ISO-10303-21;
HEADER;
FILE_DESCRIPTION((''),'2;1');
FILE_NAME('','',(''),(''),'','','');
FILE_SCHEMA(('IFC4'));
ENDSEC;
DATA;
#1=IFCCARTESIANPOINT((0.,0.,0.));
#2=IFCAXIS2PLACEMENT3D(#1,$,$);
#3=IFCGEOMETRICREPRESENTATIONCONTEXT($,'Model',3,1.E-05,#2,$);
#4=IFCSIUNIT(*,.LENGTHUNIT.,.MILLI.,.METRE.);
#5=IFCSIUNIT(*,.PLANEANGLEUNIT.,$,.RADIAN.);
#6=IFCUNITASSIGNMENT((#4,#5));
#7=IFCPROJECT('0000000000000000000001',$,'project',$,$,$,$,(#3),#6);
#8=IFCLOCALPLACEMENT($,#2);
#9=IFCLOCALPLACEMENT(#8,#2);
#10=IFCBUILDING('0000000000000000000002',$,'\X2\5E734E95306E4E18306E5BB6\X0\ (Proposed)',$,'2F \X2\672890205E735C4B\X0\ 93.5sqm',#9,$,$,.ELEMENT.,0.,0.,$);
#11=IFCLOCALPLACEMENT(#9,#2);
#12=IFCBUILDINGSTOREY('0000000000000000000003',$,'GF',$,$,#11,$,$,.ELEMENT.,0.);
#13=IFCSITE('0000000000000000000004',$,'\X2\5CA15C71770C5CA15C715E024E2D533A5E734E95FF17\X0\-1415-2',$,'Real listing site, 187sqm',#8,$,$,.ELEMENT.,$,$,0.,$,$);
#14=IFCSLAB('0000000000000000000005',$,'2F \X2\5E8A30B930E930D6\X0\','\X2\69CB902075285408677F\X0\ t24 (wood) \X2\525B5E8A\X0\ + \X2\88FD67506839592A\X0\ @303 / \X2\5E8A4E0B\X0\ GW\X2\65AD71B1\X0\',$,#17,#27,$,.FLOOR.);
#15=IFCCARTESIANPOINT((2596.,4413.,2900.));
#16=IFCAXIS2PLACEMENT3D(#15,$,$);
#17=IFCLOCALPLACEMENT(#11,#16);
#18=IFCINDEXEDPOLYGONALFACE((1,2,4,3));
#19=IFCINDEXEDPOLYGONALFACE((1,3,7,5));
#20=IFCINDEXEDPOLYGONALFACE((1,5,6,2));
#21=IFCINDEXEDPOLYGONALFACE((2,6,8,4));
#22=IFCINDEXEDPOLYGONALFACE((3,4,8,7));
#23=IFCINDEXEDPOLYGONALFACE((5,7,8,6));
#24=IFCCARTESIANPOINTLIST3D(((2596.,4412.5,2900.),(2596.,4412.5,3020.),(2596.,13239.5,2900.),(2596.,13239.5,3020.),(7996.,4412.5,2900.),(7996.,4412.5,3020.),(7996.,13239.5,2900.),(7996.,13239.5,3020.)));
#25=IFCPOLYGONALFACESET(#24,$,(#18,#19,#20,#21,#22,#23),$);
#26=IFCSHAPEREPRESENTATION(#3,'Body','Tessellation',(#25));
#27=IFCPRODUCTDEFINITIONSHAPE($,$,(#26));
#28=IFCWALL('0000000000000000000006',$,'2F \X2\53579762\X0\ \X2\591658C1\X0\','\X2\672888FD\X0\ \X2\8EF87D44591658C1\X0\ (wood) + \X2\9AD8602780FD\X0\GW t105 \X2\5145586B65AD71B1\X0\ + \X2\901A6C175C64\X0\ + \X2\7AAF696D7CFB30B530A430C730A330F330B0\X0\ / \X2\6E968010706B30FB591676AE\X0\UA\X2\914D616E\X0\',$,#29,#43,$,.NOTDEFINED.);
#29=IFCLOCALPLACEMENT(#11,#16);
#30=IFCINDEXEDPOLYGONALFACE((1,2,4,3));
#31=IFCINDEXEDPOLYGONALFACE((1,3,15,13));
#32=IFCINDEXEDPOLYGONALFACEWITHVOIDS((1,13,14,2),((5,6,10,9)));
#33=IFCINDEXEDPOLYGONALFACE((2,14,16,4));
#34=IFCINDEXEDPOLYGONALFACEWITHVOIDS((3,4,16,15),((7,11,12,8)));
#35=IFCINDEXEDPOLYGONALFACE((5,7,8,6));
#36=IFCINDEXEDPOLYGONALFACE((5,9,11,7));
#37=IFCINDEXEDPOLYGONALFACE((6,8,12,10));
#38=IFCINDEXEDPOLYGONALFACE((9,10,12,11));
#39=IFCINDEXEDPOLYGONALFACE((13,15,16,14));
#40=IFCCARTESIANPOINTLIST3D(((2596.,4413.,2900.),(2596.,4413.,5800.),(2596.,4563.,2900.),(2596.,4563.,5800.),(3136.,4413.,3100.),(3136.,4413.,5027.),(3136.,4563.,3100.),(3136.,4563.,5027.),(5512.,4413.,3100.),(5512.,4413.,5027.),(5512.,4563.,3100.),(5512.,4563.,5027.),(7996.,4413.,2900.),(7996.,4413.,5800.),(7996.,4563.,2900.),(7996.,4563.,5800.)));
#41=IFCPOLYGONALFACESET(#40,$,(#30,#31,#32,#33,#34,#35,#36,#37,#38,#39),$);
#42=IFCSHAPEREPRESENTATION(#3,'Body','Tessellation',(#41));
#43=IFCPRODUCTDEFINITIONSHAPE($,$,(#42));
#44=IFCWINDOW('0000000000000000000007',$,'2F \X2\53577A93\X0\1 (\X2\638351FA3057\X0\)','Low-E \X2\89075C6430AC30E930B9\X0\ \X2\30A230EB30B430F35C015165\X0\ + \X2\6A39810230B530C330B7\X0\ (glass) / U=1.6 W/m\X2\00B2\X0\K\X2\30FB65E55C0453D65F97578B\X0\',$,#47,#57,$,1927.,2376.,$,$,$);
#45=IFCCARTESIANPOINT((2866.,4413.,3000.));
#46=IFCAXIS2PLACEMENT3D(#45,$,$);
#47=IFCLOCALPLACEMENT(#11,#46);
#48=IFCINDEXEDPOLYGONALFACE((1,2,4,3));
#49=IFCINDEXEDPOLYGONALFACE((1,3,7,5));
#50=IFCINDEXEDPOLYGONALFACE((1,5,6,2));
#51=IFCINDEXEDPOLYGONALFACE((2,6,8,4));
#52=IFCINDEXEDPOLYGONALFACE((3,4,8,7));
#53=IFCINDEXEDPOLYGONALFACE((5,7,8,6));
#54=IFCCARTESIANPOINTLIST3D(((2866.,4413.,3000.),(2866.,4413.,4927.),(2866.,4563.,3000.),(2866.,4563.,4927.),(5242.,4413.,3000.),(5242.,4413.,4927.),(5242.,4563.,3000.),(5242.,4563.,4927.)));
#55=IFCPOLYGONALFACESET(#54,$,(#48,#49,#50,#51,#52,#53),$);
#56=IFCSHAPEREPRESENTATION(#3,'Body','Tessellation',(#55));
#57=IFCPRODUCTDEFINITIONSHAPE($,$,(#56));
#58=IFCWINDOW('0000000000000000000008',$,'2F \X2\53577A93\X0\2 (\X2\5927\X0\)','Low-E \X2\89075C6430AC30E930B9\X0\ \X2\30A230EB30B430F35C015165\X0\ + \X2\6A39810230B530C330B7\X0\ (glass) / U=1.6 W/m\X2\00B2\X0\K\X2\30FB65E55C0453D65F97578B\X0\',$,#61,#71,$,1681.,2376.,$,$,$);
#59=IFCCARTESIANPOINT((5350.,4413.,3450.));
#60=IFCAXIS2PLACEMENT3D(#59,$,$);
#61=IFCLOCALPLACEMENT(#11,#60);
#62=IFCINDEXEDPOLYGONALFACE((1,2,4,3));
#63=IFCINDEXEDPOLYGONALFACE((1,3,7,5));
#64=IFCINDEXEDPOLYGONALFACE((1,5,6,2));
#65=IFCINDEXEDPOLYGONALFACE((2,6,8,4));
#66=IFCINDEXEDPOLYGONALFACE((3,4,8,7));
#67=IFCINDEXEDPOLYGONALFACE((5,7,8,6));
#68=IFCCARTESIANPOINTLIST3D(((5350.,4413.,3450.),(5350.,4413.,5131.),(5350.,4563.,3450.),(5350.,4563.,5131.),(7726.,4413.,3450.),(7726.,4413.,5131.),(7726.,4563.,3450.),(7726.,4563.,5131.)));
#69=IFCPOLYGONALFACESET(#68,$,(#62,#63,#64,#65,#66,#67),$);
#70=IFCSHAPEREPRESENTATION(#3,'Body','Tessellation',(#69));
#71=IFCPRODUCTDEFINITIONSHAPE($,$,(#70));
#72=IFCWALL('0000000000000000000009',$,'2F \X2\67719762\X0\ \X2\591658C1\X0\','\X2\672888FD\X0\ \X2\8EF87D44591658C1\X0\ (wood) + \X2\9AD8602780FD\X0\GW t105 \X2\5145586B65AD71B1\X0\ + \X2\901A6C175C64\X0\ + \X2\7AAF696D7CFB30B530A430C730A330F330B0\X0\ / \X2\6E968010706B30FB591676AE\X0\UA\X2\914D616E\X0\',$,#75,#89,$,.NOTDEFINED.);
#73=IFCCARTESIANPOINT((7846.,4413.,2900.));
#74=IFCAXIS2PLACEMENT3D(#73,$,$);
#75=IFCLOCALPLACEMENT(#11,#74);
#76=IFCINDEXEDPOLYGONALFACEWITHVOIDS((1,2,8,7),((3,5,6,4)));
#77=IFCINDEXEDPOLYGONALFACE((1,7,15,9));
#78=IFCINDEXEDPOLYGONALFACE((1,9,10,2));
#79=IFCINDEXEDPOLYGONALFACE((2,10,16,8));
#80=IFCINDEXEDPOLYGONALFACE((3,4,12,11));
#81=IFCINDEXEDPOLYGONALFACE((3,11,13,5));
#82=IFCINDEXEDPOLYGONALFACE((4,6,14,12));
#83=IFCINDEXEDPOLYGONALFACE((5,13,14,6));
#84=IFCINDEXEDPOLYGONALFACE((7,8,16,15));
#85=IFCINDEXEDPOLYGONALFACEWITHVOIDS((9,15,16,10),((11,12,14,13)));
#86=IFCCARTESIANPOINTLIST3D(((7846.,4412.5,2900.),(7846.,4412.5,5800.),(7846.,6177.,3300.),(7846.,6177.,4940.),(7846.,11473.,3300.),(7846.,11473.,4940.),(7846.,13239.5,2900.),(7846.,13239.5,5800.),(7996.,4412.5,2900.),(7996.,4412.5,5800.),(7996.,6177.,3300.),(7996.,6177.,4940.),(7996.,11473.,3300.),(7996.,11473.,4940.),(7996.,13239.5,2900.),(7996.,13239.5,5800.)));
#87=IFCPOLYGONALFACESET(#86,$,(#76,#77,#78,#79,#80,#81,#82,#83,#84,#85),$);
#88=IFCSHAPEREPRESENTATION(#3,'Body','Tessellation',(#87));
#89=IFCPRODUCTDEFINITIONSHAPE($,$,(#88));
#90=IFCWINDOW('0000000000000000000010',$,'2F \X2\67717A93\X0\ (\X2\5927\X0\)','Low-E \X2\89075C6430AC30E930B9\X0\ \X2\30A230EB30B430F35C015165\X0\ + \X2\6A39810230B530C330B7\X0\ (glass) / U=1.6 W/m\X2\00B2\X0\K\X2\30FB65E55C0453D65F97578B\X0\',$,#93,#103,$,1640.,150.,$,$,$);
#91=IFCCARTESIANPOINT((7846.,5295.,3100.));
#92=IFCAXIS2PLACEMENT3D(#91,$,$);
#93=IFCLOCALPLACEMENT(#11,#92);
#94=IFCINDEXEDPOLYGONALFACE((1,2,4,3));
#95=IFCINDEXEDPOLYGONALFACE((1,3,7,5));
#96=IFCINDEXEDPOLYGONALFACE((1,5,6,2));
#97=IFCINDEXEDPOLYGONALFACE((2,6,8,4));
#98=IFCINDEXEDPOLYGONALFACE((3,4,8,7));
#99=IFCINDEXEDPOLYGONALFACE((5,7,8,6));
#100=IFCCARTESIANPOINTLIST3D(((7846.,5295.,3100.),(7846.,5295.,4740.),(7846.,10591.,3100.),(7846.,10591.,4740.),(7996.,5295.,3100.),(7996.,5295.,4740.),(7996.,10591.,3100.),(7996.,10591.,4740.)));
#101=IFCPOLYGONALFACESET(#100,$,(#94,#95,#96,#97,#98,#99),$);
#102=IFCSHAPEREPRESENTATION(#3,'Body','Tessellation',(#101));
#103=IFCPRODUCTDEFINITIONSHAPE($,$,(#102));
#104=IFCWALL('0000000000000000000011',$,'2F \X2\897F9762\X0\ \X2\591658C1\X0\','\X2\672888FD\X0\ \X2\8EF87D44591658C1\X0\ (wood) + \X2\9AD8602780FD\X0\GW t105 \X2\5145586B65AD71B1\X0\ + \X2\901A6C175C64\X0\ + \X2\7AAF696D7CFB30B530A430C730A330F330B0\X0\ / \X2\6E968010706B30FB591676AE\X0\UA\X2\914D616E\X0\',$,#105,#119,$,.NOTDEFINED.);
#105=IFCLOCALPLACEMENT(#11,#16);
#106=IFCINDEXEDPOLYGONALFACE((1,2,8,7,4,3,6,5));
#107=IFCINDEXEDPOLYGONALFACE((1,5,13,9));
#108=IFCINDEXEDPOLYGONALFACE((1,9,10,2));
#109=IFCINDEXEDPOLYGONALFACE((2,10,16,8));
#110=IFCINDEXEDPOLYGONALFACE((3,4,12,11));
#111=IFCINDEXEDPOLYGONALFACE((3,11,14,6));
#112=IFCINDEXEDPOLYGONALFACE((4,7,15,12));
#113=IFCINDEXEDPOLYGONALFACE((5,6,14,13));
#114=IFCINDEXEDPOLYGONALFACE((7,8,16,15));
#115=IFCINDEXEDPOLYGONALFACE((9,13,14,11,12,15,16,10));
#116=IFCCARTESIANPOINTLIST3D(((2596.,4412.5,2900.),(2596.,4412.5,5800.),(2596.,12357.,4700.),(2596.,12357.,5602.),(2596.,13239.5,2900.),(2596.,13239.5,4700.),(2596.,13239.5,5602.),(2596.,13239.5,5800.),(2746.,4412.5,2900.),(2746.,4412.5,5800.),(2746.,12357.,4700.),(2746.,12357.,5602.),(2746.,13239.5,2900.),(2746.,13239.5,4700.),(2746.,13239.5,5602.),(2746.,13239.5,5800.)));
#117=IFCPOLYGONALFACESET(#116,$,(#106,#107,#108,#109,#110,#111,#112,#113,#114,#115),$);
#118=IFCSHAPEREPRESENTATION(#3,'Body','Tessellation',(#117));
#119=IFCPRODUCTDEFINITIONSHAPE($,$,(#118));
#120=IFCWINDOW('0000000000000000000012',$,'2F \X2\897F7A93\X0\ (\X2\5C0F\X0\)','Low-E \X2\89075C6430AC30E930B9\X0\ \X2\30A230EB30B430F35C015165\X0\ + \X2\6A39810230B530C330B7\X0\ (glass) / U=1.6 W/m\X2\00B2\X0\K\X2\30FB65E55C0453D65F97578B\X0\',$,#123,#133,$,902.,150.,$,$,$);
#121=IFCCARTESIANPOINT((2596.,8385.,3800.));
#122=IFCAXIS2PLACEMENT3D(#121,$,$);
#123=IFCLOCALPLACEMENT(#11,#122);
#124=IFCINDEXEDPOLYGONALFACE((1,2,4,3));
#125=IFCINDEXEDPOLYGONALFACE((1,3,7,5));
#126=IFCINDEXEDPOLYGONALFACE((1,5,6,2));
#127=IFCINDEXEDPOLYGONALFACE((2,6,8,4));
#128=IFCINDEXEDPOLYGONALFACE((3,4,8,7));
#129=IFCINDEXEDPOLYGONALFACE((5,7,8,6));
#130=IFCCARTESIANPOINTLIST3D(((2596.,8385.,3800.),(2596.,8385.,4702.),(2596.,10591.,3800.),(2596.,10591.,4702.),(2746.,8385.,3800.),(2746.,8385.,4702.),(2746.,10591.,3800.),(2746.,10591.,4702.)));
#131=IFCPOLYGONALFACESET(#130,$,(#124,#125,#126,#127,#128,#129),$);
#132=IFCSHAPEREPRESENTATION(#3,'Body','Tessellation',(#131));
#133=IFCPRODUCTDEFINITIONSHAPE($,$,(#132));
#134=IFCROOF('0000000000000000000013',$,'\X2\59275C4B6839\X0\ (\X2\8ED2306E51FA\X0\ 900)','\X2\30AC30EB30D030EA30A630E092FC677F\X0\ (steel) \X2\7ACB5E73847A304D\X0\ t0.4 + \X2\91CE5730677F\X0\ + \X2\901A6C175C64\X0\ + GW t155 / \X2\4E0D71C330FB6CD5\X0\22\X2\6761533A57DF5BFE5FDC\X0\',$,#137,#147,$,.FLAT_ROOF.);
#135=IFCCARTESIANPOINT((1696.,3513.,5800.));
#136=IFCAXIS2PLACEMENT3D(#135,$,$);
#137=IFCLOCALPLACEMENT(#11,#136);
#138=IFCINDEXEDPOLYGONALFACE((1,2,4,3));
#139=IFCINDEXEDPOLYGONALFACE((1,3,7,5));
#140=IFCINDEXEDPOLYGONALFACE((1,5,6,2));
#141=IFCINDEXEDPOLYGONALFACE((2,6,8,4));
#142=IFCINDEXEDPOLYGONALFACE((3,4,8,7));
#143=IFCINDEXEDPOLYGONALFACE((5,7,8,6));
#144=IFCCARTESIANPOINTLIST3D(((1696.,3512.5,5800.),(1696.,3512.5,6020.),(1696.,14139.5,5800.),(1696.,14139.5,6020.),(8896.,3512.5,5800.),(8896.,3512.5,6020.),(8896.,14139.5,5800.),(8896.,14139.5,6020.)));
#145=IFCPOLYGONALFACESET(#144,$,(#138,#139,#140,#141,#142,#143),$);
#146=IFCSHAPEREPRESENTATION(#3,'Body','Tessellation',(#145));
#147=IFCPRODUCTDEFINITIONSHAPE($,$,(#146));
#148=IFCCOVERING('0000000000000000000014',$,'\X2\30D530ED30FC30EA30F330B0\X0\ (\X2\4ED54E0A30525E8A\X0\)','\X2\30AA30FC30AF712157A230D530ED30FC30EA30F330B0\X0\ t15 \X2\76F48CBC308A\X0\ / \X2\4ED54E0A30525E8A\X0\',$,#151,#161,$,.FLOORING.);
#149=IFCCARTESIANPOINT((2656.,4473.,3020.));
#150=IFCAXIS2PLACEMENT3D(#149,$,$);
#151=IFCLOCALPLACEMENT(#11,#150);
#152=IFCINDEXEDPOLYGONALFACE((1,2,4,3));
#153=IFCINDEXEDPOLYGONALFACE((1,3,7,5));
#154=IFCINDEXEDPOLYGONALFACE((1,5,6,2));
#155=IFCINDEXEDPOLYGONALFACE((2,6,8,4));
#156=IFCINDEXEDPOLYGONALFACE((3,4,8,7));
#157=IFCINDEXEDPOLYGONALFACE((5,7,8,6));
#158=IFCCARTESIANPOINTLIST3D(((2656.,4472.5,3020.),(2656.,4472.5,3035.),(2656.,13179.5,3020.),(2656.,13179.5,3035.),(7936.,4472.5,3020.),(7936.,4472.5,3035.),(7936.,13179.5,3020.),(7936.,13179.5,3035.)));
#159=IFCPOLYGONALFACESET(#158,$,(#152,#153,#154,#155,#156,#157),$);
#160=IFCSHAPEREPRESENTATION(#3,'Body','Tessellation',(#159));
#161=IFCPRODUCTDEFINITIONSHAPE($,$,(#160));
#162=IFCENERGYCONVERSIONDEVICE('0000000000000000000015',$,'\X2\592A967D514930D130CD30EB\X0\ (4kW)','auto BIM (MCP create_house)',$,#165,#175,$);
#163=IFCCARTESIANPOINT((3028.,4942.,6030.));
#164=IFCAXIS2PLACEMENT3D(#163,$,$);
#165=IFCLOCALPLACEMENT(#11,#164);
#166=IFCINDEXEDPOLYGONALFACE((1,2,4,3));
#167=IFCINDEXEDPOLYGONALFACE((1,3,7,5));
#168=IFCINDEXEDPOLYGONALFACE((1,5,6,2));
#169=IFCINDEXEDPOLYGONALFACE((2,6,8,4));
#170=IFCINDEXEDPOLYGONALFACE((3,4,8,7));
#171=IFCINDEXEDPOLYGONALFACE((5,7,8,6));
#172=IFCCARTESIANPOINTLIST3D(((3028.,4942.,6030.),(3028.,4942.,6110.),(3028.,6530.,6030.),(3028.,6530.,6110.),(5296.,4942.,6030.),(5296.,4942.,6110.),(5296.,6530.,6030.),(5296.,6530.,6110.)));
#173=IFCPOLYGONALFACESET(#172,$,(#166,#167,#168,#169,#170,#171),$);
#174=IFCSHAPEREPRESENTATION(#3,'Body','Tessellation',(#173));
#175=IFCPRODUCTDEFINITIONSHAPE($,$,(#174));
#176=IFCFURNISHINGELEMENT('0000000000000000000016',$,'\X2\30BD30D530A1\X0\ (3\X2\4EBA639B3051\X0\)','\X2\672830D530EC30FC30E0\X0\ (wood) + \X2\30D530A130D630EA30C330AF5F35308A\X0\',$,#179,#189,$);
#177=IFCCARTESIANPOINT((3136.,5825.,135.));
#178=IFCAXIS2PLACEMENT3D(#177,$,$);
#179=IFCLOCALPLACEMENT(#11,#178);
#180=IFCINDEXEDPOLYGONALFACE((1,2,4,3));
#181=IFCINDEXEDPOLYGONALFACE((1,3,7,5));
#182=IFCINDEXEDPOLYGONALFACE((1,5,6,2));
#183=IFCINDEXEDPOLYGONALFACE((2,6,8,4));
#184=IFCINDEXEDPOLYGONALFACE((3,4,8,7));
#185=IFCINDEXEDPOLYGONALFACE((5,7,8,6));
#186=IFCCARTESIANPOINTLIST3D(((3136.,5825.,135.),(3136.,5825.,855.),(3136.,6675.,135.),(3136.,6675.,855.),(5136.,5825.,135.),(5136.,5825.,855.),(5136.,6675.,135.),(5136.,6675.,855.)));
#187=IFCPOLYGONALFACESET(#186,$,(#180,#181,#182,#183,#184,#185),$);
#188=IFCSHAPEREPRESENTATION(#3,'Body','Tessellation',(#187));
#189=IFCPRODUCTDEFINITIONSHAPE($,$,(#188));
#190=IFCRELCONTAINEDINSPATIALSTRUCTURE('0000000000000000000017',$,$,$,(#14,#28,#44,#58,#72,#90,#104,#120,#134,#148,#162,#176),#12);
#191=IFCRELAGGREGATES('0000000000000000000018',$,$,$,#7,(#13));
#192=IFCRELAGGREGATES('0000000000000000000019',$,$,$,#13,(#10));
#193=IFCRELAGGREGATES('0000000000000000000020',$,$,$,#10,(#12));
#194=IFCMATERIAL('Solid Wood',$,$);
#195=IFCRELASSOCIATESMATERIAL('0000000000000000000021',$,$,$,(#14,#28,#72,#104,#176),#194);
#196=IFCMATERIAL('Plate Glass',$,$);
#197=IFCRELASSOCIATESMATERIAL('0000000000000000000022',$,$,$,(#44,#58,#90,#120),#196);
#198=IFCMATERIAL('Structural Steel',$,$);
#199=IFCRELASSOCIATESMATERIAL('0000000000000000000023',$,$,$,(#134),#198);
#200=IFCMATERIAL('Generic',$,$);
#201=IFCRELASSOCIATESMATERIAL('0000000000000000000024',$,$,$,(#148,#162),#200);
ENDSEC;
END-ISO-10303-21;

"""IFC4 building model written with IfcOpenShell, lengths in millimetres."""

from ifc_helpers import new_model, si_unit, frame, frame_2d, origin, place, context, project, spatial, rectangle, extrude, material, element, fill, save


model = new_model("IFC4")

# Units and contexts
model_context = context("Model", 3, precision=1e-05, world=origin())
ifc_project = project(units=[si_unit("LENGTHUNIT", "METRE", prefix="MILLI"), si_unit("PLANEANGLEUNIT", "RADIAN")], contexts=[model_context])

# Site, building, storey
site_placement = place(None, origin())
site = spatial("IfcSite", under=ifc_project, at=site_placement, Name="岡山県岡山市中区平井７-1415-2", ObjectType="Real listing site, 187sqm", CompositionType="ELEMENT", RefElevation=0.0)
building_placement = place(site_placement, origin())
building = spatial("IfcBuilding", under=site, at=building_placement, Name="平井の丘の家 (Proposed)", ObjectType="2F 木造平屋 93.5sqm", CompositionType="ELEMENT", ElevationOfRefHeight=0.0, ElevationOfTerrain=0.0)
storey_placement = place(building_placement, origin())
storey = spatial("IfcBuildingStorey", under=building, at=storey_placement, Name="GF", CompositionType="ELEMENT", Elevation=0.0)

# Slab
ifc_material_1 = material(Name="Solid Wood")
slab_placement = place(storey_placement, frame((2596.0, 4413.0, 2900.0)))
element("IfcSlab", 1, at=slab_placement, inside=storey, material=ifc_material_1, Name="2F 床スラブ", Description="構造用合板 t24 (wood) 剛床 + 製材根太 @303 / 床下 GW断熱", PredefinedType="FLOOR", context=model_context, shape_type="SweptSolid", body=[
    extrude(rectangle(XDim=5400.0, YDim=8827.0, at=frame_2d((2700.0, 4413.0))), frame((2596.0, 4413.0, 2900.0)), (0.0, 0.0, 1.0), 120.0),
])

# Wall, openings, windows
wall_1_placement = place(storey_placement, frame((2596.0, 4413.0, 2900.0)))
wall_1 = element("IfcWall", 2, at=wall_1_placement, inside=storey, material=ifc_material_1, Name="2F 南面 外壁", Description="木製 軸組外壁 (wood) + 高性能GW t105 充填断熱 + 通気層 + 窯業系サイディング / 準耐火・外皮UA配慮", PredefinedType="NOTDEFINED", context=model_context, shape_type="SweptSolid", body=[
    extrude(rectangle(XDim=5400.0, YDim=150.0, at=frame_2d((2700.0, 75.0))), frame((2596.0, 4413.0, 2900.0)), (0.0, 0.0, 1.0), 2900.0),
])
opening_1_placement = place(storey_placement, frame((2866.0, 4413.0, 3000.0)))
opening_1 = element("IfcOpeningElement", 3, at=opening_1_placement, cuts=wall_1, PredefinedType="NOTDEFINED", context=model_context, shape_type="SweptSolid", body=[
    extrude(rectangle(XDim=2376.0, YDim=150.0, at=frame_2d((1188.0, 75.0))), frame((2866.0, 4413.0, 3000.0)), (0.0, 0.0, 1.0), 1927.0),
])
opening_2_placement = place(storey_placement, frame((5350.0, 4413.0, 3450.0)))
opening_2 = element("IfcOpeningElement", 4, at=opening_2_placement, cuts=wall_1, PredefinedType="NOTDEFINED", context=model_context, shape_type="SweptSolid", body=[
    extrude(rectangle(XDim=2376.0, YDim=150.0, at=frame_2d((1188.0, 75.0))), frame((5350.0, 4413.0, 3450.0)), (0.0, 0.0, 1.0), 1681.0),
])
ifc_material_2 = material(Name="Plate Glass")
window_1_placement = place(storey_placement, frame((2866.0, 4413.0, 3000.0)))
window_1 = element("IfcWindow", 5, at=window_1_placement, inside=storey, material=ifc_material_2, Name="2F 南窓1 (掃出し)", Description="Low-E 複層ガラス アルゴン封入 + 樹脂サッシ (glass) / U=1.6 W/m²K・日射取得型", OverallHeight=1927.0, OverallWidth=2376.0, context=model_context, shape_type="SweptSolid", body=[
    extrude(rectangle(XDim=2376.0, YDim=150.0, at=frame_2d((1188.0, 75.0))), frame((2866.0, 4413.0, 3000.0)), (0.0, 0.0, 1.0), 1927.0),
])
fill(opening_1, window_1)
window_2_placement = place(storey_placement, frame((5350.0, 4413.0, 3450.0)))
window_2 = element("IfcWindow", 6, at=window_2_placement, inside=storey, material=ifc_material_2, Name="2F 南窓2 (大)", Description="Low-E 複層ガラス アルゴン封入 + 樹脂サッシ (glass) / U=1.6 W/m²K・日射取得型", OverallHeight=1681.0, OverallWidth=2376.0, context=model_context, shape_type="SweptSolid", body=[
    extrude(rectangle(XDim=2376.0, YDim=150.0, at=frame_2d((1188.0, 75.0))), frame((5350.0, 4413.0, 3450.0)), (0.0, 0.0, 1.0), 1681.0),
])
fill(opening_2, window_2)

# Walls, openings, windows
wall_2_placement = place(storey_placement, frame((7846.0, 4413.0, 2900.0)))
wall_2 = element("IfcWall", 7, at=wall_2_placement, inside=storey, material=ifc_material_1, Name="2F 東面 外壁", Description="木製 軸組外壁 (wood) + 高性能GW t105 充填断熱 + 通気層 + 窯業系サイディング / 準耐火・外皮UA配慮", PredefinedType="NOTDEFINED", context=model_context, shape_type="SweptSolid", body=[
    extrude(rectangle(XDim=150.0, YDim=8827.0, at=frame_2d((75.0, 4413.0))), frame((7846.0, 4413.0, 2900.0)), (0.0, 0.0, 1.0), 2900.0),
])
opening_3_placement = place(storey_placement, frame((7846.0, 5295.0, 3100.0)))
opening_3 = element("IfcOpeningElement", 8, at=opening_3_placement, cuts=wall_2, PredefinedType="NOTDEFINED", context=model_context, shape_type="SweptSolid", body=[
    extrude(rectangle(XDim=150.0, YDim=5296.0, at=frame_2d((75.0, 2648.0))), frame((7846.0, 5295.0, 3100.0)), (0.0, 0.0, 1.0), 1640.0),
])
window_3_placement = place(storey_placement, frame((7846.0, 5295.0, 3100.0)))
window_3 = element("IfcWindow", 9, at=window_3_placement, inside=storey, material=ifc_material_2, Name="2F 東窓 (大)", Description="Low-E 複層ガラス アルゴン封入 + 樹脂サッシ (glass) / U=1.6 W/m²K・日射取得型", OverallHeight=1640.0, OverallWidth=150.0, context=model_context, shape_type="SweptSolid", body=[
    extrude(rectangle(XDim=150.0, YDim=5296.0, at=frame_2d((75.0, 2648.0))), frame((7846.0, 5295.0, 3100.0)), (0.0, 0.0, 1.0), 1640.0),
])
fill(opening_3, window_3)
wall_3_placement = place(storey_placement, frame((2596.0, 4413.0, 2900.0)))
wall_3 = element("IfcWall", 10, at=wall_3_placement, inside=storey, material=ifc_material_1, Name="2F 西面 外壁", Description="木製 軸組外壁 (wood) + 高性能GW t105 充填断熱 + 通気層 + 窯業系サイディング / 準耐火・外皮UA配慮", PredefinedType="NOTDEFINED", context=model_context, shape_type="SweptSolid", body=[
    extrude(rectangle(XDim=150.0, YDim=8827.0, at=frame_2d((75.0, 4413.0))), frame((2596.0, 4413.0, 2900.0)), (0.0, 0.0, 1.0), 2900.0),
])
opening_4_placement = place(storey_placement, frame((2596.0, 8385.0, 3800.0)))
opening_4 = element("IfcOpeningElement", 11, at=opening_4_placement, cuts=wall_3, PredefinedType="NOTDEFINED", context=model_context, shape_type="SweptSolid", body=[
    extrude(rectangle(XDim=150.0, YDim=2206.0, at=frame_2d((75.0, 1103.0))), frame((2596.0, 8385.0, 3800.0)), (0.0, 0.0, 1.0), 902.0),
])
window_4_placement = place(storey_placement, frame((2596.0, 8385.0, 3800.0)))
window_4 = element("IfcWindow", 12, at=window_4_placement, inside=storey, material=ifc_material_2, Name="2F 西窓 (小)", Description="Low-E 複層ガラス アルゴン封入 + 樹脂サッシ (glass) / U=1.6 W/m²K・日射取得型", OverallHeight=902.0, OverallWidth=150.0, context=model_context, shape_type="SweptSolid", body=[
    extrude(rectangle(XDim=150.0, YDim=2206.0, at=frame_2d((75.0, 1103.0))), frame((2596.0, 8385.0, 3800.0)), (0.0, 0.0, 1.0), 902.0),
])
fill(opening_4, window_4)

# Roof
ifc_material_3 = material(Name="Structural Steel")
roof_placement = place(storey_placement, frame((1696.0, 3513.0, 5800.0)))
element("IfcRoof", 13, at=roof_placement, inside=storey, material=ifc_material_3, Name="大屋根 (軒の出 900)", Description="ガルバリウム鋼板 (steel) 立平葺き t0.4 + 野地板 + 通気層 + GW t155 / 不燃・法22条区域対応", PredefinedType="FLAT_ROOF", context=model_context, shape_type="SweptSolid", body=[
    extrude(rectangle(XDim=7200.0, YDim=10627.0, at=frame_2d((3600.0, 5313.0))), frame((1696.0, 3513.0, 5800.0)), (0.0, 0.0, 1.0), 220.0),
])

# Covering
ifc_material_4 = material(Name="Generic")
covering_placement = place(storey_placement, frame((2656.0, 4473.0, 3020.0)))
element("IfcCovering", 14, at=covering_placement, inside=storey, material=ifc_material_4, Name="フローリング (仕上げ床)", Description="オーク無垢フローリング t15 直貼り / 仕上げ床", PredefinedType="FLOORING", context=model_context, shape_type="SweptSolid", body=[
    extrude(rectangle(XDim=5280.0, YDim=8707.0, at=frame_2d((2640.0, 4353.0))), frame((2656.0, 4473.0, 3020.0)), (0.0, 0.0, 1.0), 15.0),
])

# Energy conversion device
energy_conversion_device_placement = place(storey_placement, frame((3028.0, 4942.0, 6030.0)))
element("IfcEnergyConversionDevice", 15, at=energy_conversion_device_placement, inside=storey, material=ifc_material_4, Name="太陽光パネル (4kW)", Description="auto BIM (MCP create_house)", context=model_context, shape_type="SweptSolid", body=[
    extrude(rectangle(XDim=2268.0, YDim=1588.0, at=frame_2d((1134.0, 794.0))), frame((3028.0, 4942.0, 6030.0)), (0.0, 0.0, 1.0), 80.0),
])

# Furnishing element
furnishing_1_placement = place(storey_placement, frame((3136.0, 5825.0, 135.0)))
element("IfcFurnishingElement", 16, at=furnishing_1_placement, inside=storey, material=ifc_material_1, Name="ソファ (3人掛け)", Description="木フレーム (wood) + ファブリック張り", context=model_context, shape_type="SweptSolid", body=[
    extrude(rectangle(XDim=2000.0, YDim=850.0, at=frame_2d((1000.0, 425.0))), frame((3136.0, 5825.0, 135.0)), (0.0, 0.0, 1.0), 720.0),
])

save(model, "model.ifc")
